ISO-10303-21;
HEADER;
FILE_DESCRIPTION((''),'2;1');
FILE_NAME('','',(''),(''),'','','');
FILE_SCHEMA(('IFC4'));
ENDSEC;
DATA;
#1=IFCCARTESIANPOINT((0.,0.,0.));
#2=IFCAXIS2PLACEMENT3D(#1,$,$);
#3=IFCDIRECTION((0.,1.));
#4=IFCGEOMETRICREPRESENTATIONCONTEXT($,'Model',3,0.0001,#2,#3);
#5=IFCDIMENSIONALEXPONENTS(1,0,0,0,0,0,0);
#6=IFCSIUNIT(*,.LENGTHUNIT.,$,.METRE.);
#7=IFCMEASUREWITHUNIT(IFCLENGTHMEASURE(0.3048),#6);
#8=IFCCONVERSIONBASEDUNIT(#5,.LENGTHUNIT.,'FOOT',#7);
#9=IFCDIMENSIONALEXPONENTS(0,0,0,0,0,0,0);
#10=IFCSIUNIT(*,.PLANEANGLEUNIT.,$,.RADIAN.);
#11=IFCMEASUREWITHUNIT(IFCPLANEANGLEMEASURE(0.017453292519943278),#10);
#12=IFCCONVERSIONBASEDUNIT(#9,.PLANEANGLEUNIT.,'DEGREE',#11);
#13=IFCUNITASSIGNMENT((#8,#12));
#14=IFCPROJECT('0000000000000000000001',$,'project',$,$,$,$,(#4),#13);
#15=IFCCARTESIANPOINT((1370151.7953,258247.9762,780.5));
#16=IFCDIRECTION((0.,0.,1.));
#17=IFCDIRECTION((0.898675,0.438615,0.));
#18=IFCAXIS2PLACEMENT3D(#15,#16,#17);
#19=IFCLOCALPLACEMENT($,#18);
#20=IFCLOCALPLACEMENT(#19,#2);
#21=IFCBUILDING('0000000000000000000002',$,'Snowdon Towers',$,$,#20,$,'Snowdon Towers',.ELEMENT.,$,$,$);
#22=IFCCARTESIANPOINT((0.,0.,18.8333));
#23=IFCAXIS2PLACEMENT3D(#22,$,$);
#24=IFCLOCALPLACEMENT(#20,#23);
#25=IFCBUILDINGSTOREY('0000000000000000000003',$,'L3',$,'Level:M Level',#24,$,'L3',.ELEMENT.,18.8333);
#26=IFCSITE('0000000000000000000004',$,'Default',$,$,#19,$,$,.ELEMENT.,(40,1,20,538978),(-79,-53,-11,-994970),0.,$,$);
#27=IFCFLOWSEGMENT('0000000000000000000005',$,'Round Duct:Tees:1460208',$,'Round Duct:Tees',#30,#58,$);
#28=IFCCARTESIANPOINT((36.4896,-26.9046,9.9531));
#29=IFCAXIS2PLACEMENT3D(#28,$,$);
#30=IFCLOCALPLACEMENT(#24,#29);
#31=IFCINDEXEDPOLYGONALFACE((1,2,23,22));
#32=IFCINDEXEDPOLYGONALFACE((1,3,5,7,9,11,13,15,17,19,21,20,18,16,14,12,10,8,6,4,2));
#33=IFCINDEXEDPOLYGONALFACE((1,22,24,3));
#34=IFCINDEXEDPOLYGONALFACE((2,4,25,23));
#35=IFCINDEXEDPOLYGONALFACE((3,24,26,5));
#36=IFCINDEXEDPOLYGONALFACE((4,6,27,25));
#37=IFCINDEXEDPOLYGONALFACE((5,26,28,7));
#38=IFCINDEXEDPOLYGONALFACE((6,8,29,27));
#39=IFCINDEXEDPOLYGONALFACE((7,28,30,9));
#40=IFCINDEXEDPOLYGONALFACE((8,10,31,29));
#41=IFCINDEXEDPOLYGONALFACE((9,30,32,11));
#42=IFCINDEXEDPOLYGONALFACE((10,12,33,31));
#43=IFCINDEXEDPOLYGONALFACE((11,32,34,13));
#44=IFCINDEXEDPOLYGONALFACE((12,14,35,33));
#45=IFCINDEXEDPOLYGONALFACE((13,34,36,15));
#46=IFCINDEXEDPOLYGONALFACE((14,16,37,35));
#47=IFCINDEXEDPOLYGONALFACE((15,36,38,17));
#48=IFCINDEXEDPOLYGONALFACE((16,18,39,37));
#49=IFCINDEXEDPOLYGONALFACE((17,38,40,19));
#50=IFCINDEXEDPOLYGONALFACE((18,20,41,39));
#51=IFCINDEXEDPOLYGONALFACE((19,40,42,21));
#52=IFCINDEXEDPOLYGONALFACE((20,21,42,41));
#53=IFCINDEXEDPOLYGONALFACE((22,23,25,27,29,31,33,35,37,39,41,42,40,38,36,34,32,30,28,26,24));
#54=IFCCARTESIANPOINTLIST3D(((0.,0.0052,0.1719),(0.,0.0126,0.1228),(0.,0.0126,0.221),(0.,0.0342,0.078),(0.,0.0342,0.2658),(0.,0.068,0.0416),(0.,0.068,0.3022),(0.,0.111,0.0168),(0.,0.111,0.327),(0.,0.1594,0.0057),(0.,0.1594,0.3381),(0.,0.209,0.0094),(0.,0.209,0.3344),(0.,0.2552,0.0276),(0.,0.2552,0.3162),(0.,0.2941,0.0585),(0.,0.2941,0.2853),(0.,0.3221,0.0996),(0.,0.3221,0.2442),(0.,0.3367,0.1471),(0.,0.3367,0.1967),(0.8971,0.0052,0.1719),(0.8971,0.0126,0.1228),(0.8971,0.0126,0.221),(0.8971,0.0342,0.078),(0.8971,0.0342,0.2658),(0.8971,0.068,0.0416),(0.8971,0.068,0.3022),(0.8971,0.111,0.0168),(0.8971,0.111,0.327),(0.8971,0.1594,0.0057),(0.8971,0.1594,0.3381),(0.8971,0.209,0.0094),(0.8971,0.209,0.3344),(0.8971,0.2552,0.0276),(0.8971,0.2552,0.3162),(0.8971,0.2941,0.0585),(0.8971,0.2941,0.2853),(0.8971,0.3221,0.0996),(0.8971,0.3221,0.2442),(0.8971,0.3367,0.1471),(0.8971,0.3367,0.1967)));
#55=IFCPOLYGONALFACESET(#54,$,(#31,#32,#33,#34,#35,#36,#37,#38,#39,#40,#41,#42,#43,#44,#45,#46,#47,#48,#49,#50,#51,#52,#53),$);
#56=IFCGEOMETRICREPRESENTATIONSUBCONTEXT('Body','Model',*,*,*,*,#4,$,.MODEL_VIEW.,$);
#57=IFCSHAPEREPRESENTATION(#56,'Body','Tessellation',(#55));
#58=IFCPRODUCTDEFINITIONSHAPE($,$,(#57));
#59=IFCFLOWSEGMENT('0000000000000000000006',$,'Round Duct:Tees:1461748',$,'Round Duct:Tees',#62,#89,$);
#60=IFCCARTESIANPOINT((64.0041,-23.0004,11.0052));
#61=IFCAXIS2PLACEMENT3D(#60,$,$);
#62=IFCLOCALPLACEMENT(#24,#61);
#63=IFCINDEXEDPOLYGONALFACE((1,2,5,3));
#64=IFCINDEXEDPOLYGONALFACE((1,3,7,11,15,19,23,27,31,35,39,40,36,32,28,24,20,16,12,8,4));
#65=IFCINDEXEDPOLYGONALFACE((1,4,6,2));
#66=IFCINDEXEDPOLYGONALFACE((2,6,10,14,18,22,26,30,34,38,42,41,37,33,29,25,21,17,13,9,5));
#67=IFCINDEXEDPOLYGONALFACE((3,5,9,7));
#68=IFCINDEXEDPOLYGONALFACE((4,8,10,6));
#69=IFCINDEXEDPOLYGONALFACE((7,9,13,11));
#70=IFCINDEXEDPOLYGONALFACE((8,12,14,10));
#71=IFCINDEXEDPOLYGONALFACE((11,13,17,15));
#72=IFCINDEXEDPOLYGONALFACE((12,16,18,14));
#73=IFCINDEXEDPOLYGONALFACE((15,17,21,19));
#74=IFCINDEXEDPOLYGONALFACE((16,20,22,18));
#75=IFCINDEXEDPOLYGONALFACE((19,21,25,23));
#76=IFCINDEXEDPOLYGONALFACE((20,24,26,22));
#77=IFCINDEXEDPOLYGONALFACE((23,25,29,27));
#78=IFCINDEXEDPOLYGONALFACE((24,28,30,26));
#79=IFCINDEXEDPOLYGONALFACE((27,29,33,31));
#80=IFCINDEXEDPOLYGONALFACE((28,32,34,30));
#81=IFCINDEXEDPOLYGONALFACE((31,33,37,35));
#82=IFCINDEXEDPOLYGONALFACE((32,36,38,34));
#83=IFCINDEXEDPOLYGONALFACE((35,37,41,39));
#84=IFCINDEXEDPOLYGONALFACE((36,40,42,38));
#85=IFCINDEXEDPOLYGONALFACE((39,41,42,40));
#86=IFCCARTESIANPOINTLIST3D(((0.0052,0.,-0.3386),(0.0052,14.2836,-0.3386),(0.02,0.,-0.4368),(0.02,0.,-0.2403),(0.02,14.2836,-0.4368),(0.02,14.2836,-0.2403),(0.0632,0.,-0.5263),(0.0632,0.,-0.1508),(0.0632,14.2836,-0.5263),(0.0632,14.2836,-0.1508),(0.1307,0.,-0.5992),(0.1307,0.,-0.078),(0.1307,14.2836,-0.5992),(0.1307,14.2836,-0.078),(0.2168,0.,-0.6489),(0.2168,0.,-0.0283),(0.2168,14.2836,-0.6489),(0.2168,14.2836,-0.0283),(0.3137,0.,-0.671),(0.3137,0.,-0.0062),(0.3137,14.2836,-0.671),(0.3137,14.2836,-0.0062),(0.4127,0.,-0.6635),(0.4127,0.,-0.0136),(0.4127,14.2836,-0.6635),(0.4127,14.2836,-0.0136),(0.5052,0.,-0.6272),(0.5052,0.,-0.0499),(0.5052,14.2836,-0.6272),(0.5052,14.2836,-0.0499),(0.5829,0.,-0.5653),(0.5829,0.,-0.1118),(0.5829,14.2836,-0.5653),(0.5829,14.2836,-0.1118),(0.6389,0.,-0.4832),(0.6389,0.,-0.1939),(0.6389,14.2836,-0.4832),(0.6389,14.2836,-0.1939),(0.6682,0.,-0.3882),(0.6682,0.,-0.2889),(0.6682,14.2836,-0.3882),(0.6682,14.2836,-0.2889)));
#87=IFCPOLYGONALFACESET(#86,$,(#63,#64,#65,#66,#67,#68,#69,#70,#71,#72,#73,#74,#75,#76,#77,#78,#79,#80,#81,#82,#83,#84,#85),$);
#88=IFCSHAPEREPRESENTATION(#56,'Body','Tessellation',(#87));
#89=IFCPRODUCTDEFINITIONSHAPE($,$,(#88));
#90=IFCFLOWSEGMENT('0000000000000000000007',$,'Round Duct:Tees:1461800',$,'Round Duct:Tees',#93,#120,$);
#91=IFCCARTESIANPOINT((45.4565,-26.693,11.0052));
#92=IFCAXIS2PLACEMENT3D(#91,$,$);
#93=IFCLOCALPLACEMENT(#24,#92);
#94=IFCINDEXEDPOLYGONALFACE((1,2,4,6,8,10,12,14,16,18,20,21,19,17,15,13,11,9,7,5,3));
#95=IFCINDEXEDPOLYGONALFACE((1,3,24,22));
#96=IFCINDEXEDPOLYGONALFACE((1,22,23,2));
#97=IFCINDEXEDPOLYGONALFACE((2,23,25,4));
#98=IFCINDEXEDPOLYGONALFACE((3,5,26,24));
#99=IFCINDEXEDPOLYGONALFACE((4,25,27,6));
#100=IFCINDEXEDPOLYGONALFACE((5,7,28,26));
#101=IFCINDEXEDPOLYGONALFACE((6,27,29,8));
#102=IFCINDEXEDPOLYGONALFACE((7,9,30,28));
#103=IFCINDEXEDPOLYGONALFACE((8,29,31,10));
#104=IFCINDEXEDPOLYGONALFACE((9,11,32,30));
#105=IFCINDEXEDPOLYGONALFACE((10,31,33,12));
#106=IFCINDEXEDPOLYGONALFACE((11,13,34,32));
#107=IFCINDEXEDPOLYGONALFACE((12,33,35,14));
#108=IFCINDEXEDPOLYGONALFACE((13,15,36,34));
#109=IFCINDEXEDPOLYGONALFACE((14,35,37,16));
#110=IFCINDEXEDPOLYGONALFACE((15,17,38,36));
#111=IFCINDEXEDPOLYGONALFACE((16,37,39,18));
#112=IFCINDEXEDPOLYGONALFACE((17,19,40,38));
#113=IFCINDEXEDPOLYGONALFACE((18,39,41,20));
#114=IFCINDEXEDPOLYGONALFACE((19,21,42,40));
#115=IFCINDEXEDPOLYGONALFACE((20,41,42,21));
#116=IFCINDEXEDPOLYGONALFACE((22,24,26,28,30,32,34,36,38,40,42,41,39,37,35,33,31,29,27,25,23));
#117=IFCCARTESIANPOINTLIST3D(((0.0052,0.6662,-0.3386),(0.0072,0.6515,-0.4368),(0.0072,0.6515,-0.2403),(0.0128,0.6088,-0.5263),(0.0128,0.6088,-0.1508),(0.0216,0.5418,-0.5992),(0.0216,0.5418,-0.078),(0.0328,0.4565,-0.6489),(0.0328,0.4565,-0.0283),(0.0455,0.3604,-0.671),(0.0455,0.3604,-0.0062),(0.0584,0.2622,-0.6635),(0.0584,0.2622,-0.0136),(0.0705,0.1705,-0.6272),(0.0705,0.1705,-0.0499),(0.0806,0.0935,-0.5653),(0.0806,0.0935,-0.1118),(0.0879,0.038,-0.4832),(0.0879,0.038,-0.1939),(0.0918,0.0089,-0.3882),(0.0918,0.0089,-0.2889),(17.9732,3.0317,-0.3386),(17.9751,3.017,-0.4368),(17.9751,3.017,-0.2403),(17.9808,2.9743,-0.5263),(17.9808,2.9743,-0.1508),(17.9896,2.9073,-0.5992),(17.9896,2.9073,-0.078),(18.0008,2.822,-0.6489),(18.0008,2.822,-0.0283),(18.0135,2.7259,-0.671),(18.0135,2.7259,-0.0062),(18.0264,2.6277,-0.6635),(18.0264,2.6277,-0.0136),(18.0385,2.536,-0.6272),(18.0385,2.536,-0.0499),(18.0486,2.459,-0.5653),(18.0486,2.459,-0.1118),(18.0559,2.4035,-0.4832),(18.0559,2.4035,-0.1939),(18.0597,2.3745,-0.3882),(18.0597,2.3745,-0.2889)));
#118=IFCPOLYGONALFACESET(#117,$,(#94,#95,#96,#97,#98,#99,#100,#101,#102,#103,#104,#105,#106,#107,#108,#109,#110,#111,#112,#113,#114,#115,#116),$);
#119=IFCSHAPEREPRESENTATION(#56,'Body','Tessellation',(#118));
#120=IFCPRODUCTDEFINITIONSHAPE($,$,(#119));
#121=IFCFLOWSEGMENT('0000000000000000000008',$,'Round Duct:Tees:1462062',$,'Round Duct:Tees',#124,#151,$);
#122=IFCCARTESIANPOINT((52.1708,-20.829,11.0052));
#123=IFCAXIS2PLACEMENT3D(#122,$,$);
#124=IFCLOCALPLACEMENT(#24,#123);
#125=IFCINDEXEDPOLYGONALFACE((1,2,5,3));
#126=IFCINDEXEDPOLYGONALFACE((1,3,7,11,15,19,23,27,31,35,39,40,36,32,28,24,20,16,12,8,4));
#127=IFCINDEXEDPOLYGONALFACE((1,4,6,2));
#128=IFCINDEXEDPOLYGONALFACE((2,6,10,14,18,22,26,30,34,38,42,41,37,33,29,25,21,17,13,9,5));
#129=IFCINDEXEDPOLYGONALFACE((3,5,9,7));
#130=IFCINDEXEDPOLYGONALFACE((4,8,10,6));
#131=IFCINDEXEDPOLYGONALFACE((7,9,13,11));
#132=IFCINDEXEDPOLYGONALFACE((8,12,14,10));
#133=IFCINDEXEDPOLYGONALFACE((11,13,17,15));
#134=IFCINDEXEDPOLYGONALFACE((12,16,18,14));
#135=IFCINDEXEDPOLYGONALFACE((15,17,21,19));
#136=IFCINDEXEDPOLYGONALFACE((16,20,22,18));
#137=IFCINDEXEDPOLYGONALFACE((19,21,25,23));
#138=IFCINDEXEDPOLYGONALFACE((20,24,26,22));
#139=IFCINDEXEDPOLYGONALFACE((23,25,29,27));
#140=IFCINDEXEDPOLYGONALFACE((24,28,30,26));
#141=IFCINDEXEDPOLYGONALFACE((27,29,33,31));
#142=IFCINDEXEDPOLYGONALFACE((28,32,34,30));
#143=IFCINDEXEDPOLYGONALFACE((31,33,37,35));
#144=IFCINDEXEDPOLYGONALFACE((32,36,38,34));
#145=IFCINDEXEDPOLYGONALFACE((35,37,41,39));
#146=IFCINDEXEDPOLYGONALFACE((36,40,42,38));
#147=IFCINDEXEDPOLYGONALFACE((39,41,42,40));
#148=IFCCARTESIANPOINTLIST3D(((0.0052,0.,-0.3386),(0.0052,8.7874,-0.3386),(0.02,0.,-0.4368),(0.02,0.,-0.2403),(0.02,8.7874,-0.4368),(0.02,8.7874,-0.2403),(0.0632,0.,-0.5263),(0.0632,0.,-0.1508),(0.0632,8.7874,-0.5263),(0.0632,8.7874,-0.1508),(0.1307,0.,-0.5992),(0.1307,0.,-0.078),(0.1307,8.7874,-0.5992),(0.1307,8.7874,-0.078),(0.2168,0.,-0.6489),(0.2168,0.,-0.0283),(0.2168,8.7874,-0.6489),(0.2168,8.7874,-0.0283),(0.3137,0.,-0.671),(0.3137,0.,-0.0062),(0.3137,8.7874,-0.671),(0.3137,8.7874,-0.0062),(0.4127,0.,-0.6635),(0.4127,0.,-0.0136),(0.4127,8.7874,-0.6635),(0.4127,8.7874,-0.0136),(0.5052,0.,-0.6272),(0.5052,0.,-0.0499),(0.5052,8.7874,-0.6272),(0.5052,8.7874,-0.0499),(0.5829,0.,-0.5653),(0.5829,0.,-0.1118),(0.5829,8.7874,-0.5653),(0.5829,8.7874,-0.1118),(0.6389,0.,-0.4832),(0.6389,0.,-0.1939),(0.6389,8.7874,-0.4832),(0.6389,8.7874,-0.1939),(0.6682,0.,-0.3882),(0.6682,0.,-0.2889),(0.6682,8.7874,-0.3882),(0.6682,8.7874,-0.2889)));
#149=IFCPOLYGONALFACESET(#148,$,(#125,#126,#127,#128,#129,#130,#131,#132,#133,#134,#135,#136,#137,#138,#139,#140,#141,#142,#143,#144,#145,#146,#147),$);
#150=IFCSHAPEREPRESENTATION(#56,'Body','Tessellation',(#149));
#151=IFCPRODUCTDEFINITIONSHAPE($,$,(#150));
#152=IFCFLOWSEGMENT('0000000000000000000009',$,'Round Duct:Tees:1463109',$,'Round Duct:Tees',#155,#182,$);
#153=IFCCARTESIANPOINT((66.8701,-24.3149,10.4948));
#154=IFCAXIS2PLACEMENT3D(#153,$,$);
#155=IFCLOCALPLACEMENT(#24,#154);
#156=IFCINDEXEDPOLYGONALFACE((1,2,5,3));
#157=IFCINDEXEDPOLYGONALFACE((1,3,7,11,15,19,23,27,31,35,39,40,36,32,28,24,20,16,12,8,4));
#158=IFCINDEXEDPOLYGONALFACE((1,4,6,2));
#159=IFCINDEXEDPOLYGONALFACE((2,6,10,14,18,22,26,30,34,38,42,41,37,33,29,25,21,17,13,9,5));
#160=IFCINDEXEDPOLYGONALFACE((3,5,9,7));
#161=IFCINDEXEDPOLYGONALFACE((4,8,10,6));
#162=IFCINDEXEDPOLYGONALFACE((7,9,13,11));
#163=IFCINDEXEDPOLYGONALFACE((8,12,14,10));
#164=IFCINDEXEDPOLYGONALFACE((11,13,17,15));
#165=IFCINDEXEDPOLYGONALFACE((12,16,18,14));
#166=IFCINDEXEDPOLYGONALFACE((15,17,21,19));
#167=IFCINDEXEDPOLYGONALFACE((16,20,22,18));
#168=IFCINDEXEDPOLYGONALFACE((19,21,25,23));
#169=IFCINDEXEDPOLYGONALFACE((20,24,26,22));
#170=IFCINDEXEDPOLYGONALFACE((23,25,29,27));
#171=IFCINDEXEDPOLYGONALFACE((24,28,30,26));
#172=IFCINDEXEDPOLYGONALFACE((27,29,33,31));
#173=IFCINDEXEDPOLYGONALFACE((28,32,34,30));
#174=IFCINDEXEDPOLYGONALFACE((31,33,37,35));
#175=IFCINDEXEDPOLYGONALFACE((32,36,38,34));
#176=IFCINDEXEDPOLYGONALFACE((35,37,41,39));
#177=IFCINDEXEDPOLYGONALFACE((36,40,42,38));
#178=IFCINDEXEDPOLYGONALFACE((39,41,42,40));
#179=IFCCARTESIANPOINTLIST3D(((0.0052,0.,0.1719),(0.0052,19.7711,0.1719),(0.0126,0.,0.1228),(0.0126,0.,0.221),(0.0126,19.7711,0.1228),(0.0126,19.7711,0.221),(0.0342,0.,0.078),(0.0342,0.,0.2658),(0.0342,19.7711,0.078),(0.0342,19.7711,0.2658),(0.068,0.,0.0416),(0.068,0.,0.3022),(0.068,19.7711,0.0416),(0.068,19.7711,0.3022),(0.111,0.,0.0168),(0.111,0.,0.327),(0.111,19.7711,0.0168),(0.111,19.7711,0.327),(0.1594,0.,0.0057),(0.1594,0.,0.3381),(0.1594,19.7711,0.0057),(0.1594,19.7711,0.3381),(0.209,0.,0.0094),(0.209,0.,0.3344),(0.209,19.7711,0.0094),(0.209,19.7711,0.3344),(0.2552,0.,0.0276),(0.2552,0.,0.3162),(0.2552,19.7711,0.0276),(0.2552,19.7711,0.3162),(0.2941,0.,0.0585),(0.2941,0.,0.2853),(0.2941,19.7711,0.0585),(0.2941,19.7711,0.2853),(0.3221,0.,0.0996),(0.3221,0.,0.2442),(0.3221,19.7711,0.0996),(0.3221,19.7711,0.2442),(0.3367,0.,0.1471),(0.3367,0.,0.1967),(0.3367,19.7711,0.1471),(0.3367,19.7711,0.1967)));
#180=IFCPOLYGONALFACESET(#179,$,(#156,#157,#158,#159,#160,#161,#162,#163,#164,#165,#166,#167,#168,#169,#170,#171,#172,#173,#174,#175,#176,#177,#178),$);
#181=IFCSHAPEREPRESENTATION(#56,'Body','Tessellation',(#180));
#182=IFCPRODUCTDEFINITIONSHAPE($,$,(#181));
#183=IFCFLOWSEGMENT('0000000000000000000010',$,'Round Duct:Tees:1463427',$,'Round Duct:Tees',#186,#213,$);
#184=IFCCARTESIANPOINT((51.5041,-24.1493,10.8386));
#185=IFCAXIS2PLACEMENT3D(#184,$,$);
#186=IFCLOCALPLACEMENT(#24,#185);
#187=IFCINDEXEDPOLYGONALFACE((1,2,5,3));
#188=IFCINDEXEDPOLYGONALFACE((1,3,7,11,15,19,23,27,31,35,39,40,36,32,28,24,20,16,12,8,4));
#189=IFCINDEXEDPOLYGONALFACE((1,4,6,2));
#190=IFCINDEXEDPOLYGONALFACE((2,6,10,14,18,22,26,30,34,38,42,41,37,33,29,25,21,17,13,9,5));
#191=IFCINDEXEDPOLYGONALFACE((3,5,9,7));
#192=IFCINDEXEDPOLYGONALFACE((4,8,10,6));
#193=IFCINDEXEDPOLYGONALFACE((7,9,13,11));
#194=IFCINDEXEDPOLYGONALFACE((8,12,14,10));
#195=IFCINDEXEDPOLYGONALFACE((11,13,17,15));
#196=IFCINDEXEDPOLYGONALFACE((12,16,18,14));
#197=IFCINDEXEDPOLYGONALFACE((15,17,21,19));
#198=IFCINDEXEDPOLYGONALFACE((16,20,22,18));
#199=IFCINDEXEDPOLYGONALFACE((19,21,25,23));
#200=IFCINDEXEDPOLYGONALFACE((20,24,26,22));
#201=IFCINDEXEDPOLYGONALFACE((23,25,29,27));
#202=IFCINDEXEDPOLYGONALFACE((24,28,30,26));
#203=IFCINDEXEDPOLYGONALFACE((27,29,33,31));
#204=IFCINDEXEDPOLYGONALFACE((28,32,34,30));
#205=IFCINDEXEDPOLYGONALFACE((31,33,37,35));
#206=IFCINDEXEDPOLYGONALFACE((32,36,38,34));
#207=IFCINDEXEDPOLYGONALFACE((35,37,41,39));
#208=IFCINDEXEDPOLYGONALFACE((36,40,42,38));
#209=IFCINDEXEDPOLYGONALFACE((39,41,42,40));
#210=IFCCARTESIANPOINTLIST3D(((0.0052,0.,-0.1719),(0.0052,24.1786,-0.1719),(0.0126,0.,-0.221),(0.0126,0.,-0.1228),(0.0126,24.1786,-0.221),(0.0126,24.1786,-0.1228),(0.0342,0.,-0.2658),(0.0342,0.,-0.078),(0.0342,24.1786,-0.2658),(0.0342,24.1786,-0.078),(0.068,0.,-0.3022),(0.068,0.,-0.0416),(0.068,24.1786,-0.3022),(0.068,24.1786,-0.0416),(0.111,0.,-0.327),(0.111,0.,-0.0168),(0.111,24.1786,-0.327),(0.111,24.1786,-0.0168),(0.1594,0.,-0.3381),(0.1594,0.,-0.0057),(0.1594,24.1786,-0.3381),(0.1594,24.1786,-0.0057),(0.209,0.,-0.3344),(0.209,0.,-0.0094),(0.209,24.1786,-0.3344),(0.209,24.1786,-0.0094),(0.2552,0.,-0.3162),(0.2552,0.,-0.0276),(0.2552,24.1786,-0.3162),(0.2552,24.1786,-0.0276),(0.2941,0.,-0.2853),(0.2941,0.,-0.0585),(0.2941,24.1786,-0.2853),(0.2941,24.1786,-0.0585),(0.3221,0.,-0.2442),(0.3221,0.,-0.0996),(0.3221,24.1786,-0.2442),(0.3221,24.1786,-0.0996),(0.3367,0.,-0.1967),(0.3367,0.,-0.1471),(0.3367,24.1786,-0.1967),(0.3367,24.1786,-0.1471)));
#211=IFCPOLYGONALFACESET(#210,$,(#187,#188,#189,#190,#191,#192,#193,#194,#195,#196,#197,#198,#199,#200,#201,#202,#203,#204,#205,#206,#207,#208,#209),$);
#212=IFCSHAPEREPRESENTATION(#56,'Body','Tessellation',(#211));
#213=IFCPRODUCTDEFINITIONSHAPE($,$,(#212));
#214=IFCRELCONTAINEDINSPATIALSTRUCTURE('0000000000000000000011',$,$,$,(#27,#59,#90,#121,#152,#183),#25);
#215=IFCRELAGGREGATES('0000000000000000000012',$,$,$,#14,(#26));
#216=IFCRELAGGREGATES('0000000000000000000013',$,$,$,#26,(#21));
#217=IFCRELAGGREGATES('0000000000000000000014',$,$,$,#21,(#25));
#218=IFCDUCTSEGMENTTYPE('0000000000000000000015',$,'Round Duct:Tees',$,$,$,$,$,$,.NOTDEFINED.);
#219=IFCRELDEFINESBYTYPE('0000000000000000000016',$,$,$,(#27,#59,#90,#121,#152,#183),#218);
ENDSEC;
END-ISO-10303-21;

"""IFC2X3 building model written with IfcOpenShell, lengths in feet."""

from ifc_helpers import new_model, entity, si_unit, converted_unit, direction, frame, frame_2d, origin, origin_2d_with_axis, place, context, subcontext, project, spatial, circle, extrude, type_object, element, save


model = new_model("IFC2X3")

# Units and contexts
model_context = context("Model", 3, precision=0.0001, world=origin(), true_north=direction((0.0, 1.0)))
body_context = subcontext(model_context, "Body", "Model", "MODEL_VIEW")
ifc_project = project(units=[converted_unit("LENGTHUNIT", "FOOT", entity("IfcLengthMeasure", 0.3048), si_unit("LENGTHUNIT", "METRE"), dimensions=[1, 0, 0, 0, 0, 0, 0]), converted_unit("PLANEANGLEUNIT", "DEGREE", entity("IfcPlaneAngleMeasure", 0.017453292519943278), si_unit("PLANEANGLEUNIT", "RADIAN"), dimensions=[0, 0, 0, 0, 0, 0, 0])], contexts=[model_context])

# Site, building, storey
site_placement = place(None, frame((1370151.7953, 258247.9762, 780.5), z_axis=(0.0, 0.0, 1.0), x_axis=(0.898675, 0.438615, 0.0)))
site = spatial("IfcSite", under=ifc_project, at=site_placement, Name="Default", CompositionType="ELEMENT", RefLatitude=(40, 1, 20, 538978), RefLongitude=(-79, -53, -11, -994970), RefElevation=0.0)
building_placement = place(site_placement, origin())
building = spatial("IfcBuilding", under=site, at=building_placement, Name="Snowdon Towers", LongName="Snowdon Towers", CompositionType="ELEMENT")
storey_placement = place(building_placement, frame((0.0, 0.0, 18.8333)))
storey = spatial("IfcBuildingStorey", under=building, at=storey_placement, Name="L3", ObjectType="Level:M Level", LongName="L3", CompositionType="ELEMENT", Elevation=18.8333)

# Flow segments
duct_segment_type = type_object("IfcDuctSegmentType", Name="Round Duct:Tees", PredefinedType="NOTDEFINED")
flow_segment_1_placement = place(storey_placement, frame((36.4896, -26.9046, 9.9531)))
element("IfcFlowSegment", 1, at=flow_segment_1_placement, inside=storey, type_object=duct_segment_type, Name="Round Duct:Tees:1460208", ObjectType="Round Duct:Tees", context=body_context, shape_type="SweptSolid", body=[
    extrude(circle(Radius=0.1667, at=frame_2d((0.0, 0.0), x_axis=(1.0, 0.0))), frame((0.0, 0.1719, 0.1719), z_axis=(1.0, 0.0, 0.0), x_axis=(0.0, -1.0, 0.0)), (0.0, 0.0, 1.0), 0.8971),
])
flow_segment_2_placement = place(storey_placement, frame((64.0041, -23.0004, 11.0052)))
element("IfcFlowSegment", 2, at=flow_segment_2_placement, inside=storey, type_object=duct_segment_type, Name="Round Duct:Tees:1461748", ObjectType="Round Duct:Tees", context=body_context, shape_type="SweptSolid", body=[
    extrude(circle(Radius=0.3333, at=origin_2d_with_axis()), frame((0.3386, 0.0, -0.3386), z_axis=(0.0, 1.0, 0.0), x_axis=(-1.0, 0.0, 0.0)), (0.0, 0.0, 1.0), 14.2836),
])
flow_segment_3_placement = place(storey_placement, frame((45.4565, -26.693, 11.0052)))
element("IfcFlowSegment", 3, at=flow_segment_3_placement, inside=storey, type_object=duct_segment_type, Name="Round Duct:Tees:1461800", ObjectType="Round Duct:Tees", context=body_context, shape_type="SweptSolid", body=[
    extrude(circle(Radius=0.3333, at=frame_2d((0.0, 0.0), x_axis=(1.0, 0.0))), frame((0.0487, 0.3357, -0.3386), z_axis=(0.991445, 0.130526, 0.0), x_axis=(-0.130526, 0.991445, 0.0)), (0.0, 0.0, 1.0), 18.123),
])
flow_segment_4_placement = place(storey_placement, frame((52.1708, -20.829, 11.0052)))
element("IfcFlowSegment", 4, at=flow_segment_4_placement, inside=storey, type_object=duct_segment_type, Name="Round Duct:Tees:1462062", ObjectType="Round Duct:Tees", context=body_context, shape_type="SweptSolid", body=[
    extrude(circle(Radius=0.3333, at=origin_2d_with_axis()), frame((0.3386, 0.0, -0.3386), z_axis=(0.0, 1.0, 0.0), x_axis=(-1.0, 0.0, 0.0)), (0.0, 0.0, 1.0), 8.7874),
])
flow_segment_5_placement = place(storey_placement, frame((66.8701, -24.3149, 10.4948)))
element("IfcFlowSegment", 5, at=flow_segment_5_placement, inside=storey, type_object=duct_segment_type, Name="Round Duct:Tees:1463109", ObjectType="Round Duct:Tees", context=body_context, shape_type="SweptSolid", body=[
    extrude(circle(Radius=0.1667, at=frame_2d((0.0, 0.0), x_axis=(1.0, 0.0))), frame((0.1719, 0.0, 0.1719), z_axis=(0.0, 1.0, 0.0), x_axis=(-1.0, 0.0, 0.0)), (0.0, 0.0, 1.0), 19.7711),
])
flow_segment_6_placement = place(storey_placement, frame((51.5041, -24.1493, 10.8386)))
element("IfcFlowSegment", 6, at=flow_segment_6_placement, inside=storey, type_object=duct_segment_type, Name="Round Duct:Tees:1463427", ObjectType="Round Duct:Tees", context=body_context, shape_type="SweptSolid", body=[
    extrude(circle(Radius=0.1667, at=frame_2d((0.0, 0.0), x_axis=(1.0, 0.0))), frame((0.1719, 0.0, -0.1719), z_axis=(0.0, 1.0, 0.0), x_axis=(-1.0, 0.0, 0.0)), (0.0, 0.0, 1.0), 24.1786),
])

save(model, "model.ifc")
